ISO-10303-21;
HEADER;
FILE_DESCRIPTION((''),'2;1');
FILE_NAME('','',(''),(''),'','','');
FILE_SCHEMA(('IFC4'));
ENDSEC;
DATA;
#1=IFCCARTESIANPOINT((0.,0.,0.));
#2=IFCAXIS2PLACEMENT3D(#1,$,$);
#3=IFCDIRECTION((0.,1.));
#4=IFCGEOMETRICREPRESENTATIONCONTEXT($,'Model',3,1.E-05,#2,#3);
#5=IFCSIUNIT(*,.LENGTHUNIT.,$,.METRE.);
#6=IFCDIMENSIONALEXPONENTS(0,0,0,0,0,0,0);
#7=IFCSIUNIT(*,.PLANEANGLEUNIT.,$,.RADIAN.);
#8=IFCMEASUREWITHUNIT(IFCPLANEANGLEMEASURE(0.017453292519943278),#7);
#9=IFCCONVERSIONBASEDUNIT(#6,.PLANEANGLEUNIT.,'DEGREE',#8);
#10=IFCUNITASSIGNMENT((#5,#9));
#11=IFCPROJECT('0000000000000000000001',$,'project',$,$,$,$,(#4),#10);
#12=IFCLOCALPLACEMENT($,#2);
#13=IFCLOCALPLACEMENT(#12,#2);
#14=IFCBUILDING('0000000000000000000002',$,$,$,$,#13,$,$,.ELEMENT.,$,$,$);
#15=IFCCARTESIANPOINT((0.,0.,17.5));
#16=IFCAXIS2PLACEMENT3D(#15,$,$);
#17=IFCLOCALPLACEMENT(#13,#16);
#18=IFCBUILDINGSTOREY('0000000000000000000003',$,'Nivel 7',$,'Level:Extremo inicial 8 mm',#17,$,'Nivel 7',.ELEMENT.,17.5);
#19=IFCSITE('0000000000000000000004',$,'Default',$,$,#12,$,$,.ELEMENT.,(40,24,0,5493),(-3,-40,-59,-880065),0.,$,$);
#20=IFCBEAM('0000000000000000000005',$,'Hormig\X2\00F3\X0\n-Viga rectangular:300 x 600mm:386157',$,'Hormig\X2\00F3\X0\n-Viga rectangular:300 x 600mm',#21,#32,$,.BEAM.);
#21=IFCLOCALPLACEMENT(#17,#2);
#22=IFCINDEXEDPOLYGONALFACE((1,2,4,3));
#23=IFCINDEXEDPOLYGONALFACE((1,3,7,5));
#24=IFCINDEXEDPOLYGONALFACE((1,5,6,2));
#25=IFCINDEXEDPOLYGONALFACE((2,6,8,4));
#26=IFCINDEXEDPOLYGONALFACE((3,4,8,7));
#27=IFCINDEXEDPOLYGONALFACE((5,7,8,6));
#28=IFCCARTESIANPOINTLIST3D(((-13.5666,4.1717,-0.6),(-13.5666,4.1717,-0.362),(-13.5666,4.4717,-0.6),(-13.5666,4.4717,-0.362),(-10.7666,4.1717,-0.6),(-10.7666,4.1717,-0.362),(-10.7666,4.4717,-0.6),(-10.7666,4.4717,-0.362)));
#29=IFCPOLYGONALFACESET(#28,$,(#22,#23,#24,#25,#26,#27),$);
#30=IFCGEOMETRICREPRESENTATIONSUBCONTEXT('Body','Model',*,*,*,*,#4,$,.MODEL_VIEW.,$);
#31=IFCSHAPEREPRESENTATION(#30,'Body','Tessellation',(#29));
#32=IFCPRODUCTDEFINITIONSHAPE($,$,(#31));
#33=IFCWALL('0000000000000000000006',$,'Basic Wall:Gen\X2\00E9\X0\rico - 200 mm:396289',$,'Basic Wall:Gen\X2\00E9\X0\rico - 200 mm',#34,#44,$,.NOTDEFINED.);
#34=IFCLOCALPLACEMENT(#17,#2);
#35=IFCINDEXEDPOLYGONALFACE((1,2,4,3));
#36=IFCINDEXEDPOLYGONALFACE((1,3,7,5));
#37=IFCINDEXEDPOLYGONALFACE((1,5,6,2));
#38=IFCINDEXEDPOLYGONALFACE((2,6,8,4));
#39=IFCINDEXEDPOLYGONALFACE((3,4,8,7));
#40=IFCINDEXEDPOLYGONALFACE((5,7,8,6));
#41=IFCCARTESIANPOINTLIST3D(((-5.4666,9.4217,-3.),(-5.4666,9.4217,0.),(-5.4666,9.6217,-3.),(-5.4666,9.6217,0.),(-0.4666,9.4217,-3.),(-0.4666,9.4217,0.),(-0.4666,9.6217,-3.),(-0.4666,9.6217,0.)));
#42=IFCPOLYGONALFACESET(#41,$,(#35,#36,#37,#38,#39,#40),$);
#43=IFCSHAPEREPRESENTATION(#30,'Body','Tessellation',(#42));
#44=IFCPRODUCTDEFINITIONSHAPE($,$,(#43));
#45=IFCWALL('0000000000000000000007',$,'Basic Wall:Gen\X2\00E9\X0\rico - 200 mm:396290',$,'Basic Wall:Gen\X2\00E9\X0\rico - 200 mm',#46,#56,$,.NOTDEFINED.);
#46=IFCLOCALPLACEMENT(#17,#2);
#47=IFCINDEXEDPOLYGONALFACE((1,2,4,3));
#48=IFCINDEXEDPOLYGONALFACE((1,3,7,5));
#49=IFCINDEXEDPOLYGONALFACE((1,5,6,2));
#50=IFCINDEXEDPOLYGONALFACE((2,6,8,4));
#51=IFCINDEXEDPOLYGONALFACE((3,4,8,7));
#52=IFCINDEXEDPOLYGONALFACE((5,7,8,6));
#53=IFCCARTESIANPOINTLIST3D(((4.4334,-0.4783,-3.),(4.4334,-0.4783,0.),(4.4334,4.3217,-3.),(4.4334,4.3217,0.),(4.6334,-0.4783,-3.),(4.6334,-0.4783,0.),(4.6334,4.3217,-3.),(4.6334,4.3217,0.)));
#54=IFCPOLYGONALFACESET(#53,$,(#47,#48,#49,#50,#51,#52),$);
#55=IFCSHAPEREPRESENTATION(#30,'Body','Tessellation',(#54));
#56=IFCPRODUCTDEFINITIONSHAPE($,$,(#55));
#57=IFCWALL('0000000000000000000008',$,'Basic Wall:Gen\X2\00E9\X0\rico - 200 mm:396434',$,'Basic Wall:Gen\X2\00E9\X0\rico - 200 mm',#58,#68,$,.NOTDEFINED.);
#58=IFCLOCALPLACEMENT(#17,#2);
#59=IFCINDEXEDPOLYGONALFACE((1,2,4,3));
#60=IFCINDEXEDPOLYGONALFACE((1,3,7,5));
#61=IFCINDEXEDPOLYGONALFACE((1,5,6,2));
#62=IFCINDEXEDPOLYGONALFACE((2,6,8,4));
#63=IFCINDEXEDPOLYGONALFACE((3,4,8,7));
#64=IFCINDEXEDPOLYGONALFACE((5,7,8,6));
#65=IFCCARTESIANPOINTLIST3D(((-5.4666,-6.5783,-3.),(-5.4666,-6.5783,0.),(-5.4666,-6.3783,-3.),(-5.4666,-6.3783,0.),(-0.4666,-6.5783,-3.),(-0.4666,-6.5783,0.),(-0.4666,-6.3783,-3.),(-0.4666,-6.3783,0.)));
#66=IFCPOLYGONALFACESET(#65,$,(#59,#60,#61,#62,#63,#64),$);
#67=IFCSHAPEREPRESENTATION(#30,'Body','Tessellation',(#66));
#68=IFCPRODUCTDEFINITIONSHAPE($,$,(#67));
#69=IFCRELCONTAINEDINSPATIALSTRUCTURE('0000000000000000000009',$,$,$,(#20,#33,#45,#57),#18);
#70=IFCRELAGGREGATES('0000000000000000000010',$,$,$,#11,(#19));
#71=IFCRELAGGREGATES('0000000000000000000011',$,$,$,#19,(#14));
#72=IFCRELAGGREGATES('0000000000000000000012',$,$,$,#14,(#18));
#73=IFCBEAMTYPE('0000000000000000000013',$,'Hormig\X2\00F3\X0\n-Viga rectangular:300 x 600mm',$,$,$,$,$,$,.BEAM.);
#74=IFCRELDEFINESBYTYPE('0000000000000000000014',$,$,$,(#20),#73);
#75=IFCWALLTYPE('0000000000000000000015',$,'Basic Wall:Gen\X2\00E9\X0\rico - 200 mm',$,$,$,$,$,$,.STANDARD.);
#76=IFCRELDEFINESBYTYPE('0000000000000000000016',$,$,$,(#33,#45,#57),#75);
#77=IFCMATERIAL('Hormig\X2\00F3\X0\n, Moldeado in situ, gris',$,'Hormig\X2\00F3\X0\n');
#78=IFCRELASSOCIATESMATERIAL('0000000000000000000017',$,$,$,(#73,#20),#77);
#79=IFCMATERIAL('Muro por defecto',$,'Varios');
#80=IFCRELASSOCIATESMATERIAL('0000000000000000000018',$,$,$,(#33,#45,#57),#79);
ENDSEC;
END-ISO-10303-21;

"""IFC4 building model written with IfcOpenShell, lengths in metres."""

from ifc_helpers import new_model, entity, si_unit, converted_unit, direction, frame, origin, place, context, subcontext, project, spatial, indexed_curve, outline, extrude, source, transform, mapped, material, type_object, type_shapes, element, save


model = new_model("IFC4")

# Units and contexts
model_context = context("Model", 3, precision=1e-05, world=origin(), true_north=direction((0.0, 1.0)))
body_context = subcontext(model_context, "Body", "Model", "MODEL_VIEW")
ifc_project = project(units=[si_unit("LENGTHUNIT", "METRE"), converted_unit("PLANEANGLEUNIT", "DEGREE", entity("IfcPlaneAngleMeasure", 0.017453292519943278), si_unit("PLANEANGLEUNIT", "RADIAN"), dimensions=[0, 0, 0, 0, 0, 0, 0])], contexts=[model_context])

# Site, building, storey
site_placement = place(None, origin())
site = spatial("IfcSite", under=ifc_project, at=site_placement, Name="Default", CompositionType="ELEMENT", RefLatitude=(40, 24, 0, 5493), RefLongitude=(-3, -40, -59, -880065), RefElevation=0.0)
building_placement = place(site_placement, origin())
building = spatial("IfcBuilding", under=site, at=building_placement, CompositionType="ELEMENT")
storey_placement = place(building_placement, frame((0.0, 0.0, 17.5)))
storey = spatial("IfcBuildingStorey", under=building, at=storey_placement, Name="Nivel 7", ObjectType="Level:Extremo inicial 8 mm", LongName="Nivel 7", CompositionType="ELEMENT", Elevation=17.5)

# Shared definitions
ifc_material_1 = material(Name="Hormigón, Moldeado in situ, gris", Category="Hormigón")

# Beam
beam_type_1 = type_object("IfcBeamType", Name="Hormigón-Viga rectangular:300 x 600mm", PredefinedType="BEAM", material=ifc_material_1)
shared_shape_1 = source(origin(), body_context, "Body", "SweptSolid", [
    extrude(outline(indexed_curve([(-0.119, -0.15), (0.119, -0.15), (0.119, 0.15), (-0.119, 0.15), (-0.119, -0.15)], self_intersect=False)), frame((-10.7666, 4.3217, 17.019), z_axis=(-1.0, 0.0, 0.0), x_axis=(0.0, 0.0, -1.0)), (0.0, 0.0, 1.0), 2.8),
])
type_shapes(beam_type_1, [shared_shape_1])
beam_1_placement = place(storey_placement, frame((0.0, 0.0, -17.5)))
element("IfcBeam", 1, at=beam_1_placement, inside=storey, type_object=beam_type_1, material=ifc_material_1, Name="Hormigón-Viga rectangular:300 x 600mm:386157", ObjectType="Hormigón-Viga rectangular:300 x 600mm", PredefinedType="BEAM", context=body_context, shape_type="MappedRepresentation", body=[
    mapped(shared_shape_1, transform((0.0, 0.0, 0.0), scale=1.0)),
])

# Walls
ifc_material_2 = material(Name="Muro por defecto", Category="Varios")
wall_type = type_object("IfcWallType", Name="Basic Wall:Genérico - 200 mm", PredefinedType="STANDARD")
wall_1_placement = place(storey_placement, frame((-5.4666, 9.5217, -3.0)))
element("IfcWall", 2, at=wall_1_placement, inside=storey, type_object=wall_type, material=ifc_material_2, Name="Basic Wall:Genérico - 200 mm:396289", ObjectType="Basic Wall:Genérico - 200 mm", PredefinedType="NOTDEFINED", context=body_context, shape_type="SweptSolid", body=[
    extrude(outline(indexed_curve([(5.0, 0.1), (0.0, 0.1), (0.0, -0.1), (5.0, -0.1), (5.0, 0.1)], self_intersect=False)), origin(), (0.0, 0.0, 1.0), 3.0),
])
wall_2_placement = place(storey_placement, frame((4.5334, 4.3217, -3.0), z_axis=(0.0, 0.0, 1.0), x_axis=(0.0, -1.0, 0.0)))
element("IfcWall", 3, at=wall_2_placement, inside=storey, type_object=wall_type, material=ifc_material_2, Name="Basic Wall:Genérico - 200 mm:396290", ObjectType="Basic Wall:Genérico - 200 mm", PredefinedType="NOTDEFINED", context=body_context, shape_type="SweptSolid", body=[
    extrude(outline(indexed_curve([(4.8, 0.1), (0.0, 0.1), (0.0, -0.1), (4.8, -0.1), (4.8, 0.1)], self_intersect=False)), origin(), (0.0, 0.0, 1.0), 3.0),
])
wall_3_placement = place(storey_placement, frame((-5.4666, -6.4783, -3.0)))
element("IfcWall", 4, at=wall_3_placement, inside=storey, type_object=wall_type, material=ifc_material_2, Name="Basic Wall:Genérico - 200 mm:396434", ObjectType="Basic Wall:Genérico - 200 mm", PredefinedType="NOTDEFINED", context=body_context, shape_type="SweptSolid", body=[
    extrude(outline(indexed_curve([(5.0, 0.1), (0.0, 0.1), (0.0, -0.1), (5.0, -0.1), (5.0, 0.1)], self_intersect=False)), origin(), (0.0, 0.0, 1.0), 3.0),
])

save(model, "model.ifc")
